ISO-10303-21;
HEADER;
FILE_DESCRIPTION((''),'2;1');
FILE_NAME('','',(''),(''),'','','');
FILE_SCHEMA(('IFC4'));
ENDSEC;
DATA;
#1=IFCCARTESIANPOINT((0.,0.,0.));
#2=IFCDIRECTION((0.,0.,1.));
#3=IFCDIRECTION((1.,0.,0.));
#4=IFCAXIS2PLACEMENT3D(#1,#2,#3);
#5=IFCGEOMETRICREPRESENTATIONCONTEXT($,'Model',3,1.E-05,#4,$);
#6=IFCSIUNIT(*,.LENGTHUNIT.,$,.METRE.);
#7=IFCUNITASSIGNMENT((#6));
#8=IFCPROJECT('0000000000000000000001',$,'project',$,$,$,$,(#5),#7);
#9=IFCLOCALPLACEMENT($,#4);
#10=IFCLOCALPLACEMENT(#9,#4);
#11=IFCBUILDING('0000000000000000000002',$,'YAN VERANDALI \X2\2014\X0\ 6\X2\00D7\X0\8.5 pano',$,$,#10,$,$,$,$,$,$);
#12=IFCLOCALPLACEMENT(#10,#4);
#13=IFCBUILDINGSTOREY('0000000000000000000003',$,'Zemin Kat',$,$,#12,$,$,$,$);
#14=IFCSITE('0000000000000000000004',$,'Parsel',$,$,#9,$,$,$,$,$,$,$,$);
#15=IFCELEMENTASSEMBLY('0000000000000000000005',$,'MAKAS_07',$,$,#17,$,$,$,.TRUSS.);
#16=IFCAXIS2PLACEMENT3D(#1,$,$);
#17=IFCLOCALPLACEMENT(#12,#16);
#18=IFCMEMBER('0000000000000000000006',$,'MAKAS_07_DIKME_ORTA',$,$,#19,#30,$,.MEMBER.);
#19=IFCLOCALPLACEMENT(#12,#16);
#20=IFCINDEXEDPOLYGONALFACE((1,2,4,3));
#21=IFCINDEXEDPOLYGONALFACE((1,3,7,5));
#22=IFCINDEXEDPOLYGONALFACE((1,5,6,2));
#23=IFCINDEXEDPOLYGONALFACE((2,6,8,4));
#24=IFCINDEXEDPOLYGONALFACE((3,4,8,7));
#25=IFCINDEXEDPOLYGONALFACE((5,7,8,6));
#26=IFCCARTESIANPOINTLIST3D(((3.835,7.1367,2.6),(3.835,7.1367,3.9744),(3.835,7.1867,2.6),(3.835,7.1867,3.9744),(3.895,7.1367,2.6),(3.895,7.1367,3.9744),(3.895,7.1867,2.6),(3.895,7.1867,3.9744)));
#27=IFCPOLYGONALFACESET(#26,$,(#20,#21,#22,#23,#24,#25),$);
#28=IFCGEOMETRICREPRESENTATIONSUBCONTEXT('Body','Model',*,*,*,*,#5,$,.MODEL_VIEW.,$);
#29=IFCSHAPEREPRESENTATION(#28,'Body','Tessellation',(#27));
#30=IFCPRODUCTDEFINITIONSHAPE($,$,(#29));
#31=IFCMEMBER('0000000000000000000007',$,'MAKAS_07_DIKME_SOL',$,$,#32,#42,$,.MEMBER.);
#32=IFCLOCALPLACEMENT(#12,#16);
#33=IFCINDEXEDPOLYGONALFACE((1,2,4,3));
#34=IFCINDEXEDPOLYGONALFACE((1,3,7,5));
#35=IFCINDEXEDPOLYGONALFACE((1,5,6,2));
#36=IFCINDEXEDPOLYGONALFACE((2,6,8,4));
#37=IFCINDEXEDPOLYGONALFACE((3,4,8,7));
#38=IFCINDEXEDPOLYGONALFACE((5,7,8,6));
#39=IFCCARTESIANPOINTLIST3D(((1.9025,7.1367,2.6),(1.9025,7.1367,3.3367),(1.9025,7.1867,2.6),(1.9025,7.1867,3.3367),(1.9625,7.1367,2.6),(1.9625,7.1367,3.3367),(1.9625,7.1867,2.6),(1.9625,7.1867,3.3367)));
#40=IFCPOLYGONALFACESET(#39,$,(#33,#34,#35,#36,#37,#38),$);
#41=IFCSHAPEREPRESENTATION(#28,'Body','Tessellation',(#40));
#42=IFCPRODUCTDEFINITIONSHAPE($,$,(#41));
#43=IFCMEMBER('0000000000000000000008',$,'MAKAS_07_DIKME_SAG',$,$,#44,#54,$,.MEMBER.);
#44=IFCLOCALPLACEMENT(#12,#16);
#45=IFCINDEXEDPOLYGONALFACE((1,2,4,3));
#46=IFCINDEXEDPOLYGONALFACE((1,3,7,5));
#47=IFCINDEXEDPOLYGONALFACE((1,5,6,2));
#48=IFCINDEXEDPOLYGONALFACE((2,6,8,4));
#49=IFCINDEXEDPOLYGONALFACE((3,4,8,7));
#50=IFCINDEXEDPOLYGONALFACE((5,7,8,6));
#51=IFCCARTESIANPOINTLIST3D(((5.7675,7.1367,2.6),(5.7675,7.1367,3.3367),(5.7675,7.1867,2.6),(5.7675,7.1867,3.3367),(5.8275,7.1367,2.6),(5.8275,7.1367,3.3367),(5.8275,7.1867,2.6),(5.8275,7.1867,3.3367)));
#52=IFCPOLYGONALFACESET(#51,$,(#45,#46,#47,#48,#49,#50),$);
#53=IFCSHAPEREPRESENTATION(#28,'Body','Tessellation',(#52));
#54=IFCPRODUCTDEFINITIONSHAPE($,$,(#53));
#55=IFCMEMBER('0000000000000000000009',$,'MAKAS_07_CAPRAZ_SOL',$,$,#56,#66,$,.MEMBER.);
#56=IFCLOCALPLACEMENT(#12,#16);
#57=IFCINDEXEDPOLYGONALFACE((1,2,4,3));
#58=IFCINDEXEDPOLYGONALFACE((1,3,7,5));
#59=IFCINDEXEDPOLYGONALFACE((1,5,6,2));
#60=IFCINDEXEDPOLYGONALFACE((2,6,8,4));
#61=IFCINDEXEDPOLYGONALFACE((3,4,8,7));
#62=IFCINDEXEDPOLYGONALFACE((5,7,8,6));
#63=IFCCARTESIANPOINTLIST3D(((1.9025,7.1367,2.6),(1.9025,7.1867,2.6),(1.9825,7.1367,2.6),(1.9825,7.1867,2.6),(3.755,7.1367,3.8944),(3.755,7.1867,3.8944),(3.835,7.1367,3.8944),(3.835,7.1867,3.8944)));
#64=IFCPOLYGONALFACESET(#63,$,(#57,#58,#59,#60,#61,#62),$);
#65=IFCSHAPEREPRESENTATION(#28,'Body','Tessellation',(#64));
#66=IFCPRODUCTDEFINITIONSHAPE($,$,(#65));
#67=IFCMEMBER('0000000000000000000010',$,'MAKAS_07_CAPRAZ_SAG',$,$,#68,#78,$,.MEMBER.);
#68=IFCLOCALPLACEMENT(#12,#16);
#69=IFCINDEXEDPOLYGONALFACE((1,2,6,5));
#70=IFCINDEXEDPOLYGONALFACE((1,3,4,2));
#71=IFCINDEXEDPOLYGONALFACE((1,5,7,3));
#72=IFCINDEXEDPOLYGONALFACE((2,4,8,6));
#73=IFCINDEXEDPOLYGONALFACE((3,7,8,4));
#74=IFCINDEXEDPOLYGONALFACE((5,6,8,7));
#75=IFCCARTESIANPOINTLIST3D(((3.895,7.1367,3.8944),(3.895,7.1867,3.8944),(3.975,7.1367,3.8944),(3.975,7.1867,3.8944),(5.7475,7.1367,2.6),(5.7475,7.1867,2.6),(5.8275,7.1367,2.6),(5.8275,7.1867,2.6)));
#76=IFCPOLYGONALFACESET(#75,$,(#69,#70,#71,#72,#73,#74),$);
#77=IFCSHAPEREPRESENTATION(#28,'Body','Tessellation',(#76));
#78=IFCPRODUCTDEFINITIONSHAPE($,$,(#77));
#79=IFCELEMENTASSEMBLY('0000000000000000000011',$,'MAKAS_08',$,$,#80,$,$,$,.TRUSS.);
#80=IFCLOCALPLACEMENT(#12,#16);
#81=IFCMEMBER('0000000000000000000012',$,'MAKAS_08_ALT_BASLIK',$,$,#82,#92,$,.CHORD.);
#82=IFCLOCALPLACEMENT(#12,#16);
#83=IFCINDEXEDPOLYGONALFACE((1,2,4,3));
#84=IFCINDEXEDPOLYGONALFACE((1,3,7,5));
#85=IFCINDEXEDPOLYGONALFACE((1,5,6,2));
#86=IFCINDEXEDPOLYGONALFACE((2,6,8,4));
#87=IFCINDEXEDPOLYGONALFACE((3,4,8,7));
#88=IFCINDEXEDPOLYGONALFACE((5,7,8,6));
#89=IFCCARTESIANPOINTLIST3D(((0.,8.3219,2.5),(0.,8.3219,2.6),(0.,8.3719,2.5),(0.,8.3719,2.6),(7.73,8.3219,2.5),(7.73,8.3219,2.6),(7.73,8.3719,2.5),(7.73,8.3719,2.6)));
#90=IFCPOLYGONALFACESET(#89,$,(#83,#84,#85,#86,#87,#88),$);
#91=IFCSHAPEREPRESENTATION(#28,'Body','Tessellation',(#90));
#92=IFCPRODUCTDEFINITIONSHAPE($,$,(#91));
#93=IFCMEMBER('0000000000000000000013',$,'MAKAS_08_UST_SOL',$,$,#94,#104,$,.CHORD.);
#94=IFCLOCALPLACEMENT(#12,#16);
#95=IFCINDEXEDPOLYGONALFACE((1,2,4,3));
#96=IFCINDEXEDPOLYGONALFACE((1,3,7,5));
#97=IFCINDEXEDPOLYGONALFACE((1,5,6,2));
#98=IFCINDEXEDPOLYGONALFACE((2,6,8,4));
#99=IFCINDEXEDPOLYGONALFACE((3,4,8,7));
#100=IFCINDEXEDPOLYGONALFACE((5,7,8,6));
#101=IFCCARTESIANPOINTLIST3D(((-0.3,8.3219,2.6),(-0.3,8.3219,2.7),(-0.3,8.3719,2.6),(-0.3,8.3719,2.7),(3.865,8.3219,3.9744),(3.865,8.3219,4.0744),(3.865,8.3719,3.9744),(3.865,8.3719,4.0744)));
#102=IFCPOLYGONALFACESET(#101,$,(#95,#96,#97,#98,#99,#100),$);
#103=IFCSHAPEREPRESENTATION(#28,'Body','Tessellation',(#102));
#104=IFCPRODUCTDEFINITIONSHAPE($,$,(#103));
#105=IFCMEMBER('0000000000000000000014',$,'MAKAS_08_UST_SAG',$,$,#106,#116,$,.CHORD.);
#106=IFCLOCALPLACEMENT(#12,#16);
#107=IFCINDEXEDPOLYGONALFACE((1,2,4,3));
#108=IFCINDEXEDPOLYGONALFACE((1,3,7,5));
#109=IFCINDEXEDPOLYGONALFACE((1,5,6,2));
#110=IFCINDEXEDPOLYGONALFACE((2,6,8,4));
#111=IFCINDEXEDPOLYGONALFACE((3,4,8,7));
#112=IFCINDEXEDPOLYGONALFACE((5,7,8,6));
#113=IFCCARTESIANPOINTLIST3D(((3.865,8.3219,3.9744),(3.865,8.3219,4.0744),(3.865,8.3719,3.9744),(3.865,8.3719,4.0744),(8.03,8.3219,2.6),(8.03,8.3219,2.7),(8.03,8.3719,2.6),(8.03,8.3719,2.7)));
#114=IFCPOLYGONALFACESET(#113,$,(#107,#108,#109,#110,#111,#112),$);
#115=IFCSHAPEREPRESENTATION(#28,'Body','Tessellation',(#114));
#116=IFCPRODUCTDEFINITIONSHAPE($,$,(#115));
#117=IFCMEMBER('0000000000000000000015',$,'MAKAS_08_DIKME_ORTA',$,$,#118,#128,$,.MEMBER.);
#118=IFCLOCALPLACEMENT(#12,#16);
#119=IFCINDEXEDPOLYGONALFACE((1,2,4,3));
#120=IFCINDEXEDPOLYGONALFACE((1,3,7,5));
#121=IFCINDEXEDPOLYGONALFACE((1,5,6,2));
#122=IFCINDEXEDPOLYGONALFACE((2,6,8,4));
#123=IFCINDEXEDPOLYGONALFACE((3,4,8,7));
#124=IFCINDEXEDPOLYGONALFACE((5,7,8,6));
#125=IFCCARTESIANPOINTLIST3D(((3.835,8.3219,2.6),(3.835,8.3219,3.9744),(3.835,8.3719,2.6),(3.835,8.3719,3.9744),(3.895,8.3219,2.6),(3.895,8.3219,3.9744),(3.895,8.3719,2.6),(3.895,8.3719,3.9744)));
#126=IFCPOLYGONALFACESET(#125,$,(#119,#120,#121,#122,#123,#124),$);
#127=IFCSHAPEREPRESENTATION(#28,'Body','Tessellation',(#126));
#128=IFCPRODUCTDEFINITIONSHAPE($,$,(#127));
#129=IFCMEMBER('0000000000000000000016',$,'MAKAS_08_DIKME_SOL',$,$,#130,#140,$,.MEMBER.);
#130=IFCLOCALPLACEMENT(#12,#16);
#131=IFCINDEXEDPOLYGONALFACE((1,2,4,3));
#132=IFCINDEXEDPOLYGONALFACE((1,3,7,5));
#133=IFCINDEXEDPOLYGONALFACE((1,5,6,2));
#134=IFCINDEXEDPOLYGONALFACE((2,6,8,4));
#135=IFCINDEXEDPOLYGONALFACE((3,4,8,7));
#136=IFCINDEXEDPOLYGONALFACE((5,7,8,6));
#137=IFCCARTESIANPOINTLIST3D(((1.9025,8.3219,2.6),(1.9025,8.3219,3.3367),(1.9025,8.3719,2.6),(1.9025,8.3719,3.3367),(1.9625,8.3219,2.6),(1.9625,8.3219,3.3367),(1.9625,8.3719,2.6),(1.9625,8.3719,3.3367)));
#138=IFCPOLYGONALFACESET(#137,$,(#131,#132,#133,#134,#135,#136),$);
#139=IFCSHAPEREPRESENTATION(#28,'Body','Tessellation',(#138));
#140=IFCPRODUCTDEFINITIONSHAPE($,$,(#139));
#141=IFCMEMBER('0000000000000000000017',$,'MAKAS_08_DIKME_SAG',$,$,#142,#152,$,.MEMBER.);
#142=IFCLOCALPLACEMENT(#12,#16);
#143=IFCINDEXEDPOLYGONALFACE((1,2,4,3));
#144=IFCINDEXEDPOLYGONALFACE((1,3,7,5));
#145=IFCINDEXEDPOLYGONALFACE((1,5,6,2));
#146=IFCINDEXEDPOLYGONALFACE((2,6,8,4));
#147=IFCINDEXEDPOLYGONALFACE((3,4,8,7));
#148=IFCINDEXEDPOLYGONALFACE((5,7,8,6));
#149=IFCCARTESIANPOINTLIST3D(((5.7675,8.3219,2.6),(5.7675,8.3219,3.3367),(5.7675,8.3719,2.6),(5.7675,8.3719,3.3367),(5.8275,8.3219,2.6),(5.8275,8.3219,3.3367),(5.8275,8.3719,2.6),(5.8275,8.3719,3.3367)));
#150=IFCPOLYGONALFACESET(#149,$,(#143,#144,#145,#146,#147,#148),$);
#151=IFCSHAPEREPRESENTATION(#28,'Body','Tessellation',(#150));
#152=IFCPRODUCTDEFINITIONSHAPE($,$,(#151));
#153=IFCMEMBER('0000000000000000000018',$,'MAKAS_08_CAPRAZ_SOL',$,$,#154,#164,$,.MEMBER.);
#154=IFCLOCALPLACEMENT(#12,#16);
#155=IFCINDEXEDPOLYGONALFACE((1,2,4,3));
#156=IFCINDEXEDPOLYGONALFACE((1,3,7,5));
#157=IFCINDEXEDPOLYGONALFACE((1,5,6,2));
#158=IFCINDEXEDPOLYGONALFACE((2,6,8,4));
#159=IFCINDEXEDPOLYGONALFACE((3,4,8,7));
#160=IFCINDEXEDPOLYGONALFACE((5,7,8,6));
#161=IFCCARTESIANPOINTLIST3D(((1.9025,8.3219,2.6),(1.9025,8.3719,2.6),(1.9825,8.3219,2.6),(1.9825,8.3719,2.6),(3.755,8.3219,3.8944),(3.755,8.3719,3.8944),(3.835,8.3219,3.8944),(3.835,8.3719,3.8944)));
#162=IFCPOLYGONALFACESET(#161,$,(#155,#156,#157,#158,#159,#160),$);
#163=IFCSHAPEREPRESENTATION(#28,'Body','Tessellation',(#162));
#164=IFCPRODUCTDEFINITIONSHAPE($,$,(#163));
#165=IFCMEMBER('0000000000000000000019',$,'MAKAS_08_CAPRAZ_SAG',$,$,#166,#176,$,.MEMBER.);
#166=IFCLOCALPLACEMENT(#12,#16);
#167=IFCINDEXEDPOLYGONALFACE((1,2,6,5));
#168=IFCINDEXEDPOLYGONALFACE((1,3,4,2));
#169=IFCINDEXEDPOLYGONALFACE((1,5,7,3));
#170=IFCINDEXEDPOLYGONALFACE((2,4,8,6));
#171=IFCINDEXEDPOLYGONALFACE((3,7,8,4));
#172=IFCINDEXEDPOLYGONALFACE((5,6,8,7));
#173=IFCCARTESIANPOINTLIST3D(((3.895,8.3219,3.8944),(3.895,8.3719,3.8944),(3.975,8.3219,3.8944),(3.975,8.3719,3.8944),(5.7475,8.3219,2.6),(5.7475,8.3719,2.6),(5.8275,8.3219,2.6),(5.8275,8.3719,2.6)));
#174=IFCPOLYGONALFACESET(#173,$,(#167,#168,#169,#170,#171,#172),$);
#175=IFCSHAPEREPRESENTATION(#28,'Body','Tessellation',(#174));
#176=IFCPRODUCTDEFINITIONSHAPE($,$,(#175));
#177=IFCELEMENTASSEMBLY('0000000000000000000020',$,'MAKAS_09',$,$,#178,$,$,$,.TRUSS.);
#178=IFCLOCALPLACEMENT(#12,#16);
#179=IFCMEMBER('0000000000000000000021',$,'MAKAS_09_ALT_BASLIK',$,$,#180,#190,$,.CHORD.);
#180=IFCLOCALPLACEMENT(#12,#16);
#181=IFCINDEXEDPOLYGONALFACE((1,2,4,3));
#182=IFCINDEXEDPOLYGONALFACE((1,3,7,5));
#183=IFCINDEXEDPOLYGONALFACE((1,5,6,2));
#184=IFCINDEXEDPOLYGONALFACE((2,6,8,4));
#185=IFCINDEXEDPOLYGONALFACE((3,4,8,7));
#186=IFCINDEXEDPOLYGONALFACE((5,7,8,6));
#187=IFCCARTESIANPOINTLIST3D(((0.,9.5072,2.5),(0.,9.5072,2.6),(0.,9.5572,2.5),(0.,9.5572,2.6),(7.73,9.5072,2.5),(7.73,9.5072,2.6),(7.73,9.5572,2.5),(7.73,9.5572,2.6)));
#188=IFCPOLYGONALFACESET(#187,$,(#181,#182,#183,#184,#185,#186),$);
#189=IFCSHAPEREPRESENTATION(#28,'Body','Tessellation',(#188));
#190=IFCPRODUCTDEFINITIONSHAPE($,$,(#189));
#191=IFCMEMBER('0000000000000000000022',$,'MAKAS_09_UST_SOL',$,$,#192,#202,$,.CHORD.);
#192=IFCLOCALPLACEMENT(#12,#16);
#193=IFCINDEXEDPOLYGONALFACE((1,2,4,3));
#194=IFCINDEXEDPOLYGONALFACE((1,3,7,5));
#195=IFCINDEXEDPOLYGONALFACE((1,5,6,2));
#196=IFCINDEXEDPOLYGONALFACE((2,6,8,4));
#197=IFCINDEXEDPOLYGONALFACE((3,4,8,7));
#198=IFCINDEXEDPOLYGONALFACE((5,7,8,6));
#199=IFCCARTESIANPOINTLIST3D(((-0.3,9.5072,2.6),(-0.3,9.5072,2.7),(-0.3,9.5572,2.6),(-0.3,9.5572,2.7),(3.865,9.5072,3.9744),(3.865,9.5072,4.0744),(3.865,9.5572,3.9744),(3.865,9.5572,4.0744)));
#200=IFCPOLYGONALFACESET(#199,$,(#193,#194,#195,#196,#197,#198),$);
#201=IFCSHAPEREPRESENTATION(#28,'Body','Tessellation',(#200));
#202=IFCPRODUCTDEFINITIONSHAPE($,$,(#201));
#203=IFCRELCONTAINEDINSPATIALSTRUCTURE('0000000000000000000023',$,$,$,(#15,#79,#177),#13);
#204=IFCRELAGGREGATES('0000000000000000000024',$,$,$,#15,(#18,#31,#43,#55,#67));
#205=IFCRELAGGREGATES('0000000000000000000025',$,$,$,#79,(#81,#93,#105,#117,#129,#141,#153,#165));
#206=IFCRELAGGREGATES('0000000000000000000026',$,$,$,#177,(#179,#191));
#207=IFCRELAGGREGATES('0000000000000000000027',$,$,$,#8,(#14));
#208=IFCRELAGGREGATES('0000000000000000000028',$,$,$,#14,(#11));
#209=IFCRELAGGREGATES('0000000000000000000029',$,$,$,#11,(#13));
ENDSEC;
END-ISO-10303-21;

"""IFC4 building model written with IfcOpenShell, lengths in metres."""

from ifc_helpers import new_model, si_unit, frame, origin_with_axes, place, context, subcontext, project, spatial, line, indexed_curve, outline, extrude, element, aggregate, save


model = new_model("IFC4")

# Units and contexts
model_context = context("Model", 3, precision=1e-05, world=origin_with_axes())
body_context = subcontext(model_context, "Body", "Model", "MODEL_VIEW")
ifc_project = project(units=[si_unit("LENGTHUNIT", "METRE")], contexts=[model_context])

# Site, building, storey
site_placement = place(None, origin_with_axes())
site = spatial("IfcSite", under=ifc_project, at=site_placement, Name="Parsel")
building_placement = place(site_placement, origin_with_axes())
building = spatial("IfcBuilding", under=site, at=building_placement, Name="YAN VERANDALI — 6×8.5 pano")
storey_placement = place(building_placement, origin_with_axes())
storey = spatial("IfcBuildingStorey", under=building, at=storey_placement, Name="Zemin Kat")

# Element assemblies, members
assembly_1_placement = place(storey_placement, origin_with_axes())
assembly_1 = element("IfcElementAssembly", 1, at=assembly_1_placement, inside=storey, Name="MAKAS_07", PredefinedType="TRUSS")
member_1_placement = place(assembly_1_placement, origin_with_axes())
member_1 = element("IfcMember", 2, at=member_1_placement, Name="MAKAS_07_DIKME_ORTA", PredefinedType="MEMBER", context=body_context, shape_type="SweptSolid", body=[
    extrude(outline(indexed_curve([(3.835, 2.6), (3.895, 2.6), (3.895, 3.9745), (3.835, 3.9745)], segments=[line(1, 2, 3, 4, 1)])), frame((0.0, 7.1867, 0.0), z_axis=(0.0, -1.0, 0.0), x_axis=(1.0, 0.0, 0.0)), (0.0, 0.0, 1.0), 0.05),
])
member_2_placement = place(assembly_1_placement, origin_with_axes())
member_2 = element("IfcMember", 3, at=member_2_placement, Name="MAKAS_07_DIKME_SOL", PredefinedType="MEMBER", context=body_context, shape_type="SweptSolid", body=[
    extrude(outline(indexed_curve([(1.9025, 2.6), (1.9625, 2.6), (1.9625, 3.3367), (1.9025, 3.3367)], segments=[line(1, 2, 3, 4, 1)])), frame((0.0, 7.1867, 0.0), z_axis=(0.0, -1.0, 0.0), x_axis=(1.0, 0.0, 0.0)), (0.0, 0.0, 1.0), 0.05),
])
member_3_placement = place(assembly_1_placement, origin_with_axes())
member_3 = element("IfcMember", 4, at=member_3_placement, Name="MAKAS_07_DIKME_SAG", PredefinedType="MEMBER", context=body_context, shape_type="SweptSolid", body=[
    extrude(outline(indexed_curve([(5.7675, 2.6), (5.8275, 2.6), (5.8275, 3.3367), (5.7675, 3.3367)], segments=[line(1, 2, 3, 4, 1)])), frame((0.0, 7.1867, 0.0), z_axis=(0.0, -1.0, 0.0), x_axis=(1.0, 0.0, 0.0)), (0.0, 0.0, 1.0), 0.05),
])
member_4_placement = place(assembly_1_placement, origin_with_axes())
member_4 = element("IfcMember", 5, at=member_4_placement, Name="MAKAS_07_CAPRAZ_SOL", PredefinedType="MEMBER", context=body_context, shape_type="SweptSolid", body=[
    extrude(outline(indexed_curve([(1.9025, 2.6), (1.9825, 2.6), (3.835, 3.8944), (3.755, 3.8944)], segments=[line(1, 2, 3, 4, 1)])), frame((0.0, 7.1867, 0.0), z_axis=(0.0, -1.0, 0.0), x_axis=(1.0, 0.0, 0.0)), (0.0, 0.0, 1.0), 0.05),
])
member_5_placement = place(assembly_1_placement, origin_with_axes())
member_5 = element("IfcMember", 6, at=member_5_placement, Name="MAKAS_07_CAPRAZ_SAG", PredefinedType="MEMBER", context=body_context, shape_type="SweptSolid", body=[
    extrude(outline(indexed_curve([(5.7475, 2.6), (5.8275, 2.6), (3.975, 3.8944), (3.895, 3.8944)], segments=[line(1, 2, 3, 4, 1)])), frame((0.0, 7.1867, 0.0), z_axis=(0.0, -1.0, 0.0), x_axis=(1.0, 0.0, 0.0)), (0.0, 0.0, 1.0), 0.05),
])
aggregate(assembly_1, [member_1, member_2, member_3, member_4, member_5])
assembly_2_placement = place(storey_placement, origin_with_axes())
assembly_2 = element("IfcElementAssembly", 7, at=assembly_2_placement, inside=storey, Name="MAKAS_08", PredefinedType="TRUSS")
member_6_placement = place(assembly_2_placement, origin_with_axes())
member_6 = element("IfcMember", 8, at=member_6_placement, Name="MAKAS_08_ALT_BASLIK", PredefinedType="CHORD", context=body_context, shape_type="SweptSolid", body=[
    extrude(outline(indexed_curve([(0.0, 2.5), (7.73, 2.5), (7.73, 2.6), (0.0, 2.6)], segments=[line(1, 2, 3, 4, 1)])), frame((0.0, 8.3719, 0.0), z_axis=(0.0, -1.0, 0.0), x_axis=(1.0, 0.0, 0.0)), (0.0, 0.0, 1.0), 0.05),
])
member_7_placement = place(assembly_2_placement, origin_with_axes())
member_7 = element("IfcMember", 9, at=member_7_placement, Name="MAKAS_08_UST_SOL", PredefinedType="CHORD", context=body_context, shape_type="SweptSolid", body=[
    extrude(outline(indexed_curve([(-0.3, 2.6), (3.865, 3.9745), (3.865, 4.0744), (-0.3, 2.7)], segments=[line(1, 2, 3, 4, 1)])), frame((0.0, 8.3719, 0.0), z_axis=(0.0, -1.0, 0.0), x_axis=(1.0, 0.0, 0.0)), (0.0, 0.0, 1.0), 0.05),
])
member_8_placement = place(assembly_2_placement, origin_with_axes())
member_8 = element("IfcMember", 10, at=member_8_placement, Name="MAKAS_08_UST_SAG", PredefinedType="CHORD", context=body_context, shape_type="SweptSolid", body=[
    extrude(outline(indexed_curve([(3.865, 3.9745), (8.03, 2.6), (8.03, 2.7), (3.865, 4.0744)], segments=[line(1, 2, 3, 4, 1)])), frame((0.0, 8.3719, 0.0), z_axis=(0.0, -1.0, 0.0), x_axis=(1.0, 0.0, 0.0)), (0.0, 0.0, 1.0), 0.05),
])
member_9_placement = place(assembly_2_placement, origin_with_axes())
member_9 = element("IfcMember", 11, at=member_9_placement, Name="MAKAS_08_DIKME_ORTA", PredefinedType="MEMBER", context=body_context, shape_type="SweptSolid", body=[
    extrude(outline(indexed_curve([(3.835, 2.6), (3.895, 2.6), (3.895, 3.9745), (3.835, 3.9745)], segments=[line(1, 2, 3, 4, 1)])), frame((0.0, 8.3719, 0.0), z_axis=(0.0, -1.0, 0.0), x_axis=(1.0, 0.0, 0.0)), (0.0, 0.0, 1.0), 0.05),
])
member_10_placement = place(assembly_2_placement, origin_with_axes())
member_10 = element("IfcMember", 12, at=member_10_placement, Name="MAKAS_08_DIKME_SOL", PredefinedType="MEMBER", context=body_context, shape_type="SweptSolid", body=[
    extrude(outline(indexed_curve([(1.9025, 2.6), (1.9625, 2.6), (1.9625, 3.3367), (1.9025, 3.3367)], segments=[line(1, 2, 3, 4, 1)])), frame((0.0, 8.3719, 0.0), z_axis=(0.0, -1.0, 0.0), x_axis=(1.0, 0.0, 0.0)), (0.0, 0.0, 1.0), 0.05),
])
member_11_placement = place(assembly_2_placement, origin_with_axes())
member_11 = element("IfcMember", 13, at=member_11_placement, Name="MAKAS_08_DIKME_SAG", PredefinedType="MEMBER", context=body_context, shape_type="SweptSolid", body=[
    extrude(outline(indexed_curve([(5.7675, 2.6), (5.8275, 2.6), (5.8275, 3.3367), (5.7675, 3.3367)], segments=[line(1, 2, 3, 4, 1)])), frame((0.0, 8.3719, 0.0), z_axis=(0.0, -1.0, 0.0), x_axis=(1.0, 0.0, 0.0)), (0.0, 0.0, 1.0), 0.05),
])
member_12_placement = place(assembly_2_placement, origin_with_axes())
member_12 = element("IfcMember", 14, at=member_12_placement, Name="MAKAS_08_CAPRAZ_SOL", PredefinedType="MEMBER", context=body_context, shape_type="SweptSolid", body=[
    extrude(outline(indexed_curve([(1.9025, 2.6), (1.9825, 2.6), (3.835, 3.8944), (3.755, 3.8944)], segments=[line(1, 2, 3, 4, 1)])), frame((0.0, 8.3719, 0.0), z_axis=(0.0, -1.0, 0.0), x_axis=(1.0, 0.0, 0.0)), (0.0, 0.0, 1.0), 0.05),
])
member_13_placement = place(assembly_2_placement, origin_with_axes())
member_13 = element("IfcMember", 15, at=member_13_placement, Name="MAKAS_08_CAPRAZ_SAG", PredefinedType="MEMBER", context=body_context, shape_type="SweptSolid", body=[
    extrude(outline(indexed_curve([(5.7475, 2.6), (5.8275, 2.6), (3.975, 3.8944), (3.895, 3.8944)], segments=[line(1, 2, 3, 4, 1)])), frame((0.0, 8.3719, 0.0), z_axis=(0.0, -1.0, 0.0), x_axis=(1.0, 0.0, 0.0)), (0.0, 0.0, 1.0), 0.05),
])
aggregate(assembly_2, [member_6, member_7, member_8, member_9, member_10, member_11, member_12, member_13])
assembly_3_placement = place(storey_placement, origin_with_axes())
assembly_3 = element("IfcElementAssembly", 16, at=assembly_3_placement, inside=storey, Name="MAKAS_09", PredefinedType="TRUSS")
member_14_placement = place(assembly_3_placement, origin_with_axes())
member_14 = element("IfcMember", 17, at=member_14_placement, Name="MAKAS_09_ALT_BASLIK", PredefinedType="CHORD", context=body_context, shape_type="SweptSolid", body=[
    extrude(outline(indexed_curve([(0.0, 2.5), (7.73, 2.5), (7.73, 2.6), (0.0, 2.6)], segments=[line(1, 2, 3, 4, 1)])), frame((0.0, 9.5572, 0.0), z_axis=(0.0, -1.0, 0.0), x_axis=(1.0, 0.0, 0.0)), (0.0, 0.0, 1.0), 0.05),
])
member_15_placement = place(assembly_3_placement, origin_with_axes())
member_15 = element("IfcMember", 18, at=member_15_placement, Name="MAKAS_09_UST_SOL", PredefinedType="CHORD", context=body_context, shape_type="SweptSolid", body=[
    extrude(outline(indexed_curve([(-0.3, 2.6), (3.865, 3.9745), (3.865, 4.0744), (-0.3, 2.7)], segments=[line(1, 2, 3, 4, 1)])), frame((0.0, 9.5572, 0.0), z_axis=(0.0, -1.0, 0.0), x_axis=(1.0, 0.0, 0.0)), (0.0, 0.0, 1.0), 0.05),
])
aggregate(assembly_3, [member_14, member_15])

save(model, "model.ifc")
